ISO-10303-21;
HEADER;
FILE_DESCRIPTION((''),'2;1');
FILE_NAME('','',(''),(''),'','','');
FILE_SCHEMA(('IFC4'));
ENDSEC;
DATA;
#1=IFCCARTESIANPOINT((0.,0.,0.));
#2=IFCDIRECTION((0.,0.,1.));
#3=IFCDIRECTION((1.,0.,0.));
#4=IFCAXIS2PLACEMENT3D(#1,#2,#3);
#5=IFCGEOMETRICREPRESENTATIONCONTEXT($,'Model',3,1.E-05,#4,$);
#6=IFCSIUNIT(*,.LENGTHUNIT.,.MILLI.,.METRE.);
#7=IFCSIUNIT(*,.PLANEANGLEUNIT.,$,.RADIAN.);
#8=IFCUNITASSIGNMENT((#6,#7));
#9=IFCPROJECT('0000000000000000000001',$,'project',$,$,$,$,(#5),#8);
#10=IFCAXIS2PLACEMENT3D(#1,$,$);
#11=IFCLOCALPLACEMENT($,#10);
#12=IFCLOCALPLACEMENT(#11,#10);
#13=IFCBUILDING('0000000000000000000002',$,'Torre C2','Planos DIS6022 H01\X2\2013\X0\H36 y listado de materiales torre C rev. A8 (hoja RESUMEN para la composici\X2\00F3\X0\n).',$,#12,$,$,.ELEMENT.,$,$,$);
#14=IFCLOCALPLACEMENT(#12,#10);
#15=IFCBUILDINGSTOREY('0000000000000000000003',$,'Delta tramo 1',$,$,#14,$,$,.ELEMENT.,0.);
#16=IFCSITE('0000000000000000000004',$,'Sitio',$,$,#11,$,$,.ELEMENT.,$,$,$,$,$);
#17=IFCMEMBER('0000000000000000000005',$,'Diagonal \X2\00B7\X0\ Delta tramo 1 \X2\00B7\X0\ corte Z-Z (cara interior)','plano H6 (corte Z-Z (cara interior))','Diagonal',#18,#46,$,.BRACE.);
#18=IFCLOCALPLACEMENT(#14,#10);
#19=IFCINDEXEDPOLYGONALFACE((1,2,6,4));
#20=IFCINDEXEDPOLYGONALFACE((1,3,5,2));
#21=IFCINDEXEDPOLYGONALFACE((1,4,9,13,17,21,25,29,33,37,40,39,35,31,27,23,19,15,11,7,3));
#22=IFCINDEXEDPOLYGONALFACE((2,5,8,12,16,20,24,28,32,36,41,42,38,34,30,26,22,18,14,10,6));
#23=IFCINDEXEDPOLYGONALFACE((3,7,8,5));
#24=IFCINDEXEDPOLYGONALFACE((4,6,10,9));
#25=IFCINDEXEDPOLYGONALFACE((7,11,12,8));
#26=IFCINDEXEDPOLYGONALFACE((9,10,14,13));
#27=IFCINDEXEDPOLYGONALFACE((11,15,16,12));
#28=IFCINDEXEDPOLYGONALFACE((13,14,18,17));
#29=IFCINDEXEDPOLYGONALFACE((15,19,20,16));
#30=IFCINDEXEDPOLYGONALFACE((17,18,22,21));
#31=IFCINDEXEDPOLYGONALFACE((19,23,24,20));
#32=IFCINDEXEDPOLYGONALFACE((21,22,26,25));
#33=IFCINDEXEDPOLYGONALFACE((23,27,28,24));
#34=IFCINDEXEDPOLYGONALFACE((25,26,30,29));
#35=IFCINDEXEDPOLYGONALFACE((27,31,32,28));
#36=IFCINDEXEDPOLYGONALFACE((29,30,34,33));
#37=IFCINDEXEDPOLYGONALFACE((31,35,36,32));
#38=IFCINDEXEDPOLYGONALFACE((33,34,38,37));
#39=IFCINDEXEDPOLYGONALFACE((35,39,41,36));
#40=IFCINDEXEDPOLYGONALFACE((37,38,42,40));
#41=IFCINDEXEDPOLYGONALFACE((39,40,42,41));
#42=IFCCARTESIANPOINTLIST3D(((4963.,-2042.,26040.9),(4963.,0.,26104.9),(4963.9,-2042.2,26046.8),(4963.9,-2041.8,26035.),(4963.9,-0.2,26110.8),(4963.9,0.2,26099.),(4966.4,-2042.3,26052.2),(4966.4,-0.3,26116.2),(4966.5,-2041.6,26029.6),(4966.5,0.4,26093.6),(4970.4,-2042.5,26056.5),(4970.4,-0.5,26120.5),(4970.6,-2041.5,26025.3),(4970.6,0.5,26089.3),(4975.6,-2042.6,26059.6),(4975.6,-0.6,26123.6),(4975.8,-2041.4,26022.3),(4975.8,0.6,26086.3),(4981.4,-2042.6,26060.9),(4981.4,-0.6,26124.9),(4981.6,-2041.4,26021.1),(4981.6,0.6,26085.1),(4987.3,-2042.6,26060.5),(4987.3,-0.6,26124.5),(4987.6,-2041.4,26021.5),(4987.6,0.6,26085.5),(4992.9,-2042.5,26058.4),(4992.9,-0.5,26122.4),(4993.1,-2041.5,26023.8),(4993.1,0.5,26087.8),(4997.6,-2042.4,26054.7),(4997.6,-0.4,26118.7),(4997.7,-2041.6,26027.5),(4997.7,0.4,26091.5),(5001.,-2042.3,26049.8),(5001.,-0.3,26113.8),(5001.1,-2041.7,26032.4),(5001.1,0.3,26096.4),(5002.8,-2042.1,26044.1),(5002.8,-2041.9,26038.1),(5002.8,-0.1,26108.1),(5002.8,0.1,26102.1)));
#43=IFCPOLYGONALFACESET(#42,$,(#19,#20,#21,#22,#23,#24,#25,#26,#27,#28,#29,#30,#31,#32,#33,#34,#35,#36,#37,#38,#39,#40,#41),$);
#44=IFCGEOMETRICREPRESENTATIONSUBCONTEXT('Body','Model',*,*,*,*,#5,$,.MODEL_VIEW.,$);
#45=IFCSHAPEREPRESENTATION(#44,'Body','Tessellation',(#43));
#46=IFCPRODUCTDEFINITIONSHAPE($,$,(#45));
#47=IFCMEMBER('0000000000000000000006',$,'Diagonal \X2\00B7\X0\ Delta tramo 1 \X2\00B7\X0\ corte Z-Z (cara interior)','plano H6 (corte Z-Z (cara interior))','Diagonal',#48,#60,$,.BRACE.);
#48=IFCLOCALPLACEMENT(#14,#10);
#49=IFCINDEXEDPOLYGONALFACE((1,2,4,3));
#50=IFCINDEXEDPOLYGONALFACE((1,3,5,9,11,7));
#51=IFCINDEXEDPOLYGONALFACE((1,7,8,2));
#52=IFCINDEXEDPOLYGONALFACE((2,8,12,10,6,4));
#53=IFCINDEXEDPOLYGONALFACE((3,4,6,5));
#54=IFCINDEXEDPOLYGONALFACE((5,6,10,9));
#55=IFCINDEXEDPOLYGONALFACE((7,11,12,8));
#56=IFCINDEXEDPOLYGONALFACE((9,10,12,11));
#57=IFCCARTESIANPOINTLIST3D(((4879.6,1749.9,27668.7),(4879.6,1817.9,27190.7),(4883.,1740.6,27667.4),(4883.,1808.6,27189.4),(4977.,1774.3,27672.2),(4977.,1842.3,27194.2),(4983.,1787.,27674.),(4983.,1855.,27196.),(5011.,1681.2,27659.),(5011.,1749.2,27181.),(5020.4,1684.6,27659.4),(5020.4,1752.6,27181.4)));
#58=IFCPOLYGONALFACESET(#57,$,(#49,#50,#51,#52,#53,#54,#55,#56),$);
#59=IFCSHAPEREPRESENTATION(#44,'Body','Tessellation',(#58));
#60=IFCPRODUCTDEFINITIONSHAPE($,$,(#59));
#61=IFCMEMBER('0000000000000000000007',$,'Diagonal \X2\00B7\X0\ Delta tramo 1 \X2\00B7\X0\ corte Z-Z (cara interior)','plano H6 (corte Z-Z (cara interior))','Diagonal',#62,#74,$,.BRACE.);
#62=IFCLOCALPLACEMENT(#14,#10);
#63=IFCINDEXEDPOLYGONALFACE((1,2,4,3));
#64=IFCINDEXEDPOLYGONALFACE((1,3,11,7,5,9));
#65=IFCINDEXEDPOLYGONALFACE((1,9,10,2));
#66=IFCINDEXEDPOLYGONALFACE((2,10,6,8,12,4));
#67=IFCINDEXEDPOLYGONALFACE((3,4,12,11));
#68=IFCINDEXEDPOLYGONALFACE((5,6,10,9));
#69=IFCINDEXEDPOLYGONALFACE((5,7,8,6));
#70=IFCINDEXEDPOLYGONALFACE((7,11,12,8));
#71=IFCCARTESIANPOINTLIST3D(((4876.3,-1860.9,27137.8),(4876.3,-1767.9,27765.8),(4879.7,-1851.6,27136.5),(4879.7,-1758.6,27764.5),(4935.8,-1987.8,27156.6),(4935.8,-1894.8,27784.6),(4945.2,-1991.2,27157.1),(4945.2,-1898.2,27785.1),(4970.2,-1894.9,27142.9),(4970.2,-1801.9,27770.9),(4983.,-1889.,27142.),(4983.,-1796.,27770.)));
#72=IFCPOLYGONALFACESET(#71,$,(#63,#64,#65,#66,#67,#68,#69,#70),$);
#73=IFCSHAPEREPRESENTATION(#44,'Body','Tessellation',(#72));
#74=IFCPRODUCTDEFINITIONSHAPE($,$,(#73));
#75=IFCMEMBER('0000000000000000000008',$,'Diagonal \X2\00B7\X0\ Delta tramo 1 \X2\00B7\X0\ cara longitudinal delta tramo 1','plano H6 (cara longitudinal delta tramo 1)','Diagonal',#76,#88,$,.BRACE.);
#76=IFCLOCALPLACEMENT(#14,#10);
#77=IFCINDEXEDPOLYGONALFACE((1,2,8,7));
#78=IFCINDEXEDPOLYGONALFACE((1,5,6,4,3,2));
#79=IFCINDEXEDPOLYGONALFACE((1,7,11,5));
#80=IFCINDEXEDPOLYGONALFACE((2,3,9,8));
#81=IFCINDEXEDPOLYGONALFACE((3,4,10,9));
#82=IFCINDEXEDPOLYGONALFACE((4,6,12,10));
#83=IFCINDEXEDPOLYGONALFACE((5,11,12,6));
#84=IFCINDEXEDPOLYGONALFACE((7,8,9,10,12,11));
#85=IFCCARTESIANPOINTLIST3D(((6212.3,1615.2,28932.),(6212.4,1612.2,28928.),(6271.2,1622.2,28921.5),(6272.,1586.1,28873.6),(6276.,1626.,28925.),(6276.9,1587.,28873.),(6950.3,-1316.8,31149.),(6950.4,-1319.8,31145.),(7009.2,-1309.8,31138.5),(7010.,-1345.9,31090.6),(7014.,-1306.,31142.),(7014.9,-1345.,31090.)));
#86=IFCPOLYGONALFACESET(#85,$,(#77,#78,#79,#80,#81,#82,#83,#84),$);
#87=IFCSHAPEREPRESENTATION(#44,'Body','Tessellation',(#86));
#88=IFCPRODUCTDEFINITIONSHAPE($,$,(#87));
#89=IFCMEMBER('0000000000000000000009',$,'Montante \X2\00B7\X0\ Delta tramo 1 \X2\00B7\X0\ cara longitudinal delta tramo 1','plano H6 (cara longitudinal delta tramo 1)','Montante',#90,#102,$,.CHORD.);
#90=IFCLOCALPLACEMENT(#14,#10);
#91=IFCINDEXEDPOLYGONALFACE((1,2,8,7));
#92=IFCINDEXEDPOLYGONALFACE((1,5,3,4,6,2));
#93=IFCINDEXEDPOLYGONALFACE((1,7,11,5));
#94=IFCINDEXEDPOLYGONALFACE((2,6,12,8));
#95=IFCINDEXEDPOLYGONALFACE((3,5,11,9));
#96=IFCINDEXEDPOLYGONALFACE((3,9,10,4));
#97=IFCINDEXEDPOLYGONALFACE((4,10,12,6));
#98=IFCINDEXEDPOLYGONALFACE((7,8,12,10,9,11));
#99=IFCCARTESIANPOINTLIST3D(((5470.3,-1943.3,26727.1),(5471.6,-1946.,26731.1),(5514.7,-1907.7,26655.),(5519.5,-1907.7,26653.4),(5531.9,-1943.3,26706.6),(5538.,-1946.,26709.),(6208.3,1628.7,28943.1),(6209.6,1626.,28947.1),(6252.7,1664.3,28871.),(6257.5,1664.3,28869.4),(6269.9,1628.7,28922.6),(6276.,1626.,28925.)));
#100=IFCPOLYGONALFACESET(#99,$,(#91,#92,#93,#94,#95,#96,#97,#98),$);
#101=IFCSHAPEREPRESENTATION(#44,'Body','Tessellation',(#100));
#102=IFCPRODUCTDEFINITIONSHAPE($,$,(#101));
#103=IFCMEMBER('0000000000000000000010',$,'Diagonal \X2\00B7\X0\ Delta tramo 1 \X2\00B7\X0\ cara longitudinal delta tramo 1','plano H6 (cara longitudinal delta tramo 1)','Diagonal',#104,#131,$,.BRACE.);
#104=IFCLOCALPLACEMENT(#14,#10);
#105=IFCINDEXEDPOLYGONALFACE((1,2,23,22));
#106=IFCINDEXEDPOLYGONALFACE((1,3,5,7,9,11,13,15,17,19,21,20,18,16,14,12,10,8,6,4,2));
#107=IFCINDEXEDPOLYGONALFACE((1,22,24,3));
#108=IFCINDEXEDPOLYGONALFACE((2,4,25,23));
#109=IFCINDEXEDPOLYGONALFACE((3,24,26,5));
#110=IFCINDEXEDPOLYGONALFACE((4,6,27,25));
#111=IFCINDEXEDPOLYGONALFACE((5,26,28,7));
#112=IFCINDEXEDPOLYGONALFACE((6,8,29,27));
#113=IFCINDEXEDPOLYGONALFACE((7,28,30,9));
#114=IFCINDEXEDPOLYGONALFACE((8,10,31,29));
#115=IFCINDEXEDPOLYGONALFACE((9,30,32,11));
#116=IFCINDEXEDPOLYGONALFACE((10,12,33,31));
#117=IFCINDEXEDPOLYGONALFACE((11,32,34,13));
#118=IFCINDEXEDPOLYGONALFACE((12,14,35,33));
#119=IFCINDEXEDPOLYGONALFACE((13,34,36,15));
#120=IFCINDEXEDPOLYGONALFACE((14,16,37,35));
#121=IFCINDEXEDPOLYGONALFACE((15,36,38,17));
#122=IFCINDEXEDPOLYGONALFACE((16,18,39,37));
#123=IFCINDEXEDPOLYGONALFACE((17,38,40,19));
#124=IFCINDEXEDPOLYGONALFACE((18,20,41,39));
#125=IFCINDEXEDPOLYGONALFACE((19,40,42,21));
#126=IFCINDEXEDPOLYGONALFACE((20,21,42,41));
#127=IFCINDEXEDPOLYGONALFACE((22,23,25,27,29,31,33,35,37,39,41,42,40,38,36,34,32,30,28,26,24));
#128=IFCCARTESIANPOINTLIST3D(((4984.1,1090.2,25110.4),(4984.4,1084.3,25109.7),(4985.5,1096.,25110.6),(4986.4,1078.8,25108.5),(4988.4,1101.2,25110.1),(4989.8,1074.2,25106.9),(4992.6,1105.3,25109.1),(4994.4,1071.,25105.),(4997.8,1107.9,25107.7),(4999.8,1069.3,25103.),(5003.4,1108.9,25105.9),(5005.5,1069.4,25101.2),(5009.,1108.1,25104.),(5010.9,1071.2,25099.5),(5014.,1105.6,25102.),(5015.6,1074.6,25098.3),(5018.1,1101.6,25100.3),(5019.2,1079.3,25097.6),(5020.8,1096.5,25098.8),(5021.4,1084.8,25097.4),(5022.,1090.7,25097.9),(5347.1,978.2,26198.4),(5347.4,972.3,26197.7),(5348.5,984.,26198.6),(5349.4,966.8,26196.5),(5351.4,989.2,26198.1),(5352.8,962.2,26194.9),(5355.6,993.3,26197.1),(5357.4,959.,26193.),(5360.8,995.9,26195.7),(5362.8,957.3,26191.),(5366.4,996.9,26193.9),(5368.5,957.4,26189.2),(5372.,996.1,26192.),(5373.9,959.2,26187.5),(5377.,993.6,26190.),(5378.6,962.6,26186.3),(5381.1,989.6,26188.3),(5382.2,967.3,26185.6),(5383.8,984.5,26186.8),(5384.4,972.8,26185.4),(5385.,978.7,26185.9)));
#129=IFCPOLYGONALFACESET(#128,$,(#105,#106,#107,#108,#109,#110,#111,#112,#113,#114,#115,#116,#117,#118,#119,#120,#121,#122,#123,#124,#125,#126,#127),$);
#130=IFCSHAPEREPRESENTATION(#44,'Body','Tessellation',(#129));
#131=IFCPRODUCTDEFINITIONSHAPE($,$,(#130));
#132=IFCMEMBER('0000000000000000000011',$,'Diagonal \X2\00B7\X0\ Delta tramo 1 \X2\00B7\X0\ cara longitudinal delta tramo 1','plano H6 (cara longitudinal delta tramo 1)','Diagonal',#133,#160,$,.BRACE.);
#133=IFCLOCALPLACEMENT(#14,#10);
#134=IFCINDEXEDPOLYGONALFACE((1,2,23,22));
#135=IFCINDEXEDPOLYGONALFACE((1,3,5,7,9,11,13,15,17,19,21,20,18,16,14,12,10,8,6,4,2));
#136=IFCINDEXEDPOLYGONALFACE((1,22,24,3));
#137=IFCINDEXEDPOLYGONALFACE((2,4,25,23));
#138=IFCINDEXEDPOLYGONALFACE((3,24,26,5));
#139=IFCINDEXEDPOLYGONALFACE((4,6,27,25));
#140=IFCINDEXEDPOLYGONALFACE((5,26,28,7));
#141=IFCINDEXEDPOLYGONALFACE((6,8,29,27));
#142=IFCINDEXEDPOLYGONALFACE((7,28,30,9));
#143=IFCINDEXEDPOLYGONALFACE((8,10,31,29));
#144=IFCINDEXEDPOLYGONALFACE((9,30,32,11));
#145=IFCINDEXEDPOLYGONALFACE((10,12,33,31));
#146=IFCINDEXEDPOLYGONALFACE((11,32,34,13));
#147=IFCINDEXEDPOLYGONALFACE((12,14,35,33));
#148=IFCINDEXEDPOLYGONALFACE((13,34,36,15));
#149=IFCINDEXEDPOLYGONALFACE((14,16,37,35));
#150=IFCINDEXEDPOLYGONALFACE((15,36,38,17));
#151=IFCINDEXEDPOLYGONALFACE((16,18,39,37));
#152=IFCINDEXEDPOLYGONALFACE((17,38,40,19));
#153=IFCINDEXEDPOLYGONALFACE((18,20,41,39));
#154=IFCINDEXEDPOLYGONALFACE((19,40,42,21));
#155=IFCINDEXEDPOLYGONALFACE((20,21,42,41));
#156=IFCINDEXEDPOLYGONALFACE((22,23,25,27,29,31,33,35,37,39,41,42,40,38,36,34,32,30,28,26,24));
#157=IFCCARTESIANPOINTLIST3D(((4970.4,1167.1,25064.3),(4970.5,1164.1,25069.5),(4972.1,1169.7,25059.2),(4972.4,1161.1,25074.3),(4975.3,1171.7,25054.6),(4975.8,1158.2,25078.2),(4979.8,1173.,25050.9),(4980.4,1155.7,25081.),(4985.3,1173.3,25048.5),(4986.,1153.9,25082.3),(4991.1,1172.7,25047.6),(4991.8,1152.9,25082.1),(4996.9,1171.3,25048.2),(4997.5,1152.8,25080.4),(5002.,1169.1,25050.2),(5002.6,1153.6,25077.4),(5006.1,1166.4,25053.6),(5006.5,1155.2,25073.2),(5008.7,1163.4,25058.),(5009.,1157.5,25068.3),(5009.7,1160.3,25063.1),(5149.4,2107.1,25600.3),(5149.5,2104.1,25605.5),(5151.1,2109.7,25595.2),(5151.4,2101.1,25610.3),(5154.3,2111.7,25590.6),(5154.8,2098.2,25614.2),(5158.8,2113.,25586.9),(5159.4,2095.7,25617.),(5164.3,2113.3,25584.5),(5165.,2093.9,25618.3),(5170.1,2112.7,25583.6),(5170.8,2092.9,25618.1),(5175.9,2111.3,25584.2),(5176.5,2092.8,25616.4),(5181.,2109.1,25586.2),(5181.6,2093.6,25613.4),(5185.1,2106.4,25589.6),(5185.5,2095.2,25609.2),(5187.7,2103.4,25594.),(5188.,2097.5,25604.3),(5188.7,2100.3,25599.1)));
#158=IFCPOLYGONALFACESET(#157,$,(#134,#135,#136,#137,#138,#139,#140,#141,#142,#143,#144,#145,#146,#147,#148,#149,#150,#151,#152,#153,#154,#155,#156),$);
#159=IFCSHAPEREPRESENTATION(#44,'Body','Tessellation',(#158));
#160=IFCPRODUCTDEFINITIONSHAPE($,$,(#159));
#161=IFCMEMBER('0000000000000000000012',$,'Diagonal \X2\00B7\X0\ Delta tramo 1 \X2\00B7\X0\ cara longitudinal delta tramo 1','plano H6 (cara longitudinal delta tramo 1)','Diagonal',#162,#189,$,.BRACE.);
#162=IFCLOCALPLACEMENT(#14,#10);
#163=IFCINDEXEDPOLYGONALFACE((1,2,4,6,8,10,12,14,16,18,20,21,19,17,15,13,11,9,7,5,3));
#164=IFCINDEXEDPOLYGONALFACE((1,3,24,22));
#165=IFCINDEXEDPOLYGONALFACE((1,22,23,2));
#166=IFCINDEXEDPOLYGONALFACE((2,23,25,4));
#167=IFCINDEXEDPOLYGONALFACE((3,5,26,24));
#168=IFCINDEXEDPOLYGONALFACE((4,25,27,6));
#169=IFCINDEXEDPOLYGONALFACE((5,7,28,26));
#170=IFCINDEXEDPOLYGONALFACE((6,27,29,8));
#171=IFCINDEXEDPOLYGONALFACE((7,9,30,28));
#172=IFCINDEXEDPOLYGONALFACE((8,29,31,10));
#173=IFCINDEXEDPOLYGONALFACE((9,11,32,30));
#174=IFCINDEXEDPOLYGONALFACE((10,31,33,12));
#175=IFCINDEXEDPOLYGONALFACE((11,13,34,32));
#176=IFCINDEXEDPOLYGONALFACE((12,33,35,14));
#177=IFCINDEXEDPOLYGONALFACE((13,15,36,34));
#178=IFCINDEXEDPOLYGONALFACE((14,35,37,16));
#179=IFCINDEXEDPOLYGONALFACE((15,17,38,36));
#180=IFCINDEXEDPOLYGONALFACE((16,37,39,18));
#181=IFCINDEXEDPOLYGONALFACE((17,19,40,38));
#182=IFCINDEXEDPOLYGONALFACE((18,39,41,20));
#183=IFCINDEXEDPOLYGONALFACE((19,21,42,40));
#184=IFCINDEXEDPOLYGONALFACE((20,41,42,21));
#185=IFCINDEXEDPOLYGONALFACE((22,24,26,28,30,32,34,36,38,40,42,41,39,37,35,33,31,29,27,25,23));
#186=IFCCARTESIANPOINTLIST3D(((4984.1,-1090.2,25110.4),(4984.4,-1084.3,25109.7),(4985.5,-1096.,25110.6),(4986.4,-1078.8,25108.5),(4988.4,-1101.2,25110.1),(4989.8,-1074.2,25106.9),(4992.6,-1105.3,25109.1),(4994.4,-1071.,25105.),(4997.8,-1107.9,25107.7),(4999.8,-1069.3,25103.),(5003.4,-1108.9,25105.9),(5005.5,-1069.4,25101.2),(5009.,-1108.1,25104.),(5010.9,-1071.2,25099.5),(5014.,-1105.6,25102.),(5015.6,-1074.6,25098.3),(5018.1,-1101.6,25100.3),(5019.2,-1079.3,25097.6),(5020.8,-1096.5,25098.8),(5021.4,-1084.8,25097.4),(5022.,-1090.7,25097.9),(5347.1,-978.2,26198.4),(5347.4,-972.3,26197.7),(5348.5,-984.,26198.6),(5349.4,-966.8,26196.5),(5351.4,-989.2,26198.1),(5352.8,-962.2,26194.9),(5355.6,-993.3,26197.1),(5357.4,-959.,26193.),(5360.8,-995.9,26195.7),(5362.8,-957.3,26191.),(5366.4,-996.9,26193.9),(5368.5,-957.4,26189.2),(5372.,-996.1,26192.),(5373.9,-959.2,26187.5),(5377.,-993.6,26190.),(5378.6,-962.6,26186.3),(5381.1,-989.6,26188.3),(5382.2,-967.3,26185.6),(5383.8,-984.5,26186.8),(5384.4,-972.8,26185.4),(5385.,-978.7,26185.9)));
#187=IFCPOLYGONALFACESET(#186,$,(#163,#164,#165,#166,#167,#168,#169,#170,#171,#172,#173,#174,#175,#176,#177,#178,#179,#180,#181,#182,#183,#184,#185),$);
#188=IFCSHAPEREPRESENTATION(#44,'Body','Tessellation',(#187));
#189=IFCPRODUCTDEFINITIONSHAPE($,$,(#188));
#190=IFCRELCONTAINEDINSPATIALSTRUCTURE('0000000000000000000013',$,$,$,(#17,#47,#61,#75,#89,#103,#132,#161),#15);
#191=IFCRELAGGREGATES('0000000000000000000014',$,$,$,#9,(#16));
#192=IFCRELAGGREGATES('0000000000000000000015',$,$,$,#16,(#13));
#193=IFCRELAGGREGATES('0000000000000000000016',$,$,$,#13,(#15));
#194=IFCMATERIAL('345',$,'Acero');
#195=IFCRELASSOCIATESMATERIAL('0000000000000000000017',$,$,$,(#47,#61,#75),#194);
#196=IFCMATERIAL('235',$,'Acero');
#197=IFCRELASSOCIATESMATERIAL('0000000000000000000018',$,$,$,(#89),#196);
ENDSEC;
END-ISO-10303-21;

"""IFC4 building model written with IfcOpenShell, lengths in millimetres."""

from ifc_helpers import new_model, si_unit, frame, frame_2d, origin, origin_with_axes, place, context, subcontext, project, spatial, circle, l_section, extrude, material, element, save


model = new_model("IFC4")

# Units and contexts
model_context = context("Model", 3, precision=1e-05, world=origin_with_axes())
body_context = subcontext(model_context, "Body", "Model", "MODEL_VIEW")
ifc_project = project(units=[si_unit("LENGTHUNIT", "METRE", prefix="MILLI"), si_unit("PLANEANGLEUNIT", "RADIAN")], contexts=[model_context])

# Site, building, storey
site_placement = place(None, origin())
site = spatial("IfcSite", under=ifc_project, at=site_placement, Name="Sitio", CompositionType="ELEMENT")
building_placement = place(site_placement, origin())
building = spatial("IfcBuilding", under=site, at=building_placement, Name="Torre C2", Description="Planos DIS6022 H01–H36 y listado de materiales torre C rev. A8 (hoja RESUMEN para la composición).", CompositionType="ELEMENT")
storey_placement = place(building_placement, origin())
storey = spatial("IfcBuildingStorey", under=building, at=storey_placement, Name="Delta tramo 1", CompositionType="ELEMENT", Elevation=0.0)

# Members
ifc_material_1 = material(Name="235", Category="Acero")
member_1_placement = place(storey_placement, frame((4983.0, -2042.0, 26041.0), z_axis=(0.0, 0.999509, 0.031326), x_axis=(-0.999979, 0.000201, -0.006415)))
element("IfcMember", 1, at=member_1_placement, inside=storey, Name="Diagonal · Delta tramo 1 · corte Z-Z (cara interior)", Description="plano H6 (corte Z-Z (cara interior))", ObjectType="Diagonal", PredefinedType="BRACE", context=body_context, shape_type="SweptSolid", body=[
    extrude(circle(Radius=20.0), None, (0.0, 0.0, 1.0), 2043.0),
])
ifc_material_2 = material(Name="345", Category="Acero")
member_2_placement = place(storey_placement, frame((4983.0, 1855.0, 27196.0), z_axis=(0.0, -0.140841, 0.990032), x_axis=(-0.940347, -0.336826, -0.047917)))
element("IfcMember", 2, at=member_2_placement, inside=storey, material=ifc_material_2, Name="Diagonal · Delta tramo 1 · corte Z-Z (cara interior)", Description="plano H6 (corte Z-Z (cara interior))", ObjectType="Diagonal", PredefinedType="BRACE", context=body_context, shape_type="SweptSolid", body=[
    extrude(l_section(Depth=110.0, Width=110.0, Thickness=10.0, at=frame_2d((55.0, 55.0))), None, (0.0, 0.0, 1.0), 482.8),
])
member_3_placement = place(storey_placement, frame((4983.0, -1889.0, 27142.0), z_axis=(0.0, 0.146492, 0.989212), x_axis=(-0.939149, 0.339805, -0.050321)))
element("IfcMember", 3, at=member_3_placement, inside=storey, material=ifc_material_2, Name="Diagonal · Delta tramo 1 · corte Z-Z (cara interior)", Description="plano H6 (corte Z-Z (cara interior))", ObjectType="Diagonal", PredefinedType="BRACE", context=body_context, shape_type="SweptSolid", body=[
    extrude(l_section(Depth=110.0, Width=110.0, Thickness=10.0, at=frame_2d((55.0, 55.0))), None, (0.0, 0.0, 1.0), 634.8),
])
member_4_placement = place(storey_placement, frame((6276.0, 1626.0, 28925.0), z_axis=(0.196843, -0.782037, 0.591329), x_axis=(-0.980328, -0.165892, 0.106941)))
element("IfcMember", 4, at=member_4_placement, inside=storey, material=ifc_material_2, Name="Diagonal · Delta tramo 1 · cara longitudinal delta tramo 1", Description="plano H6 (cara longitudinal delta tramo 1)", ObjectType="Diagonal", PredefinedType="BRACE", context=body_context, shape_type="SweptSolid", body=[
    extrude(l_section(Depth=65.0, Width=65.0, Thickness=5.0, at=frame_2d((32.5, 32.5))), None, (0.0, 0.0, 1.0), 3749.2),
])
member_5_placement = place(storey_placement, frame((5538.0, -1946.0, 26709.0), z_axis=(0.172921, 0.836957, 0.519232), x_axis=(-0.264454, 0.547269, -0.794079)))
element("IfcMember", 5, at=member_5_placement, inside=storey, material=ifc_material_1, Name="Montante · Delta tramo 1 · cara longitudinal delta tramo 1", Description="plano H6 (cara longitudinal delta tramo 1)", ObjectType="Montante", PredefinedType="CHORD", context=body_context, shape_type="SweptSolid", body=[
    extrude(l_section(Depth=70.0, Width=70.0, Thickness=5.0, at=frame_2d((35.0, 35.0))), None, (0.0, 0.0, 1.0), 4267.8),
])
member_6_placement = place(storey_placement, frame((5366.0, 977.0, 26192.0), z_axis=(-0.314991, 0.097187, -0.944106), x_axis=(-0.929313, -0.233618, 0.286007)))
element("IfcMember", 6, at=member_6_placement, inside=storey, Name="Diagonal · Delta tramo 1 · cara longitudinal delta tramo 1", Description="plano H6 (cara longitudinal delta tramo 1)", ObjectType="Diagonal", PredefinedType="BRACE", context=body_context, shape_type="SweptSolid", body=[
    extrude(circle(Radius=20.0), None, (0.0, 0.0, 1.0), 1152.4),
])
member_7_placement = place(storey_placement, frame((5169.0, 2103.0, 25601.0), z_axis=(-0.163204, -0.85705, -0.488701), x_axis=(-0.972761, 0.057136, 0.224657)))
element("IfcMember", 7, at=member_7_placement, inside=storey, Name="Diagonal · Delta tramo 1 · cara longitudinal delta tramo 1", Description="plano H6 (cara longitudinal delta tramo 1)", ObjectType="Diagonal", PredefinedType="BRACE", context=body_context, shape_type="SweptSolid", body=[
    extrude(circle(Radius=20.0), None, (0.0, 0.0, 1.0), 1096.8),
])
member_8_placement = place(storey_placement, frame((5366.0, -977.0, 26192.0), z_axis=(-0.314991, -0.097187, -0.944106), x_axis=(-0.929313, 0.233618, 0.286007)))
element("IfcMember", 8, at=member_8_placement, inside=storey, Name="Diagonal · Delta tramo 1 · cara longitudinal delta tramo 1", Description="plano H6 (cara longitudinal delta tramo 1)", ObjectType="Diagonal", PredefinedType="BRACE", context=body_context, shape_type="SweptSolid", body=[
    extrude(circle(Radius=20.0), None, (0.0, 0.0, 1.0), 1152.4),
])

save(model, "model.ifc")
